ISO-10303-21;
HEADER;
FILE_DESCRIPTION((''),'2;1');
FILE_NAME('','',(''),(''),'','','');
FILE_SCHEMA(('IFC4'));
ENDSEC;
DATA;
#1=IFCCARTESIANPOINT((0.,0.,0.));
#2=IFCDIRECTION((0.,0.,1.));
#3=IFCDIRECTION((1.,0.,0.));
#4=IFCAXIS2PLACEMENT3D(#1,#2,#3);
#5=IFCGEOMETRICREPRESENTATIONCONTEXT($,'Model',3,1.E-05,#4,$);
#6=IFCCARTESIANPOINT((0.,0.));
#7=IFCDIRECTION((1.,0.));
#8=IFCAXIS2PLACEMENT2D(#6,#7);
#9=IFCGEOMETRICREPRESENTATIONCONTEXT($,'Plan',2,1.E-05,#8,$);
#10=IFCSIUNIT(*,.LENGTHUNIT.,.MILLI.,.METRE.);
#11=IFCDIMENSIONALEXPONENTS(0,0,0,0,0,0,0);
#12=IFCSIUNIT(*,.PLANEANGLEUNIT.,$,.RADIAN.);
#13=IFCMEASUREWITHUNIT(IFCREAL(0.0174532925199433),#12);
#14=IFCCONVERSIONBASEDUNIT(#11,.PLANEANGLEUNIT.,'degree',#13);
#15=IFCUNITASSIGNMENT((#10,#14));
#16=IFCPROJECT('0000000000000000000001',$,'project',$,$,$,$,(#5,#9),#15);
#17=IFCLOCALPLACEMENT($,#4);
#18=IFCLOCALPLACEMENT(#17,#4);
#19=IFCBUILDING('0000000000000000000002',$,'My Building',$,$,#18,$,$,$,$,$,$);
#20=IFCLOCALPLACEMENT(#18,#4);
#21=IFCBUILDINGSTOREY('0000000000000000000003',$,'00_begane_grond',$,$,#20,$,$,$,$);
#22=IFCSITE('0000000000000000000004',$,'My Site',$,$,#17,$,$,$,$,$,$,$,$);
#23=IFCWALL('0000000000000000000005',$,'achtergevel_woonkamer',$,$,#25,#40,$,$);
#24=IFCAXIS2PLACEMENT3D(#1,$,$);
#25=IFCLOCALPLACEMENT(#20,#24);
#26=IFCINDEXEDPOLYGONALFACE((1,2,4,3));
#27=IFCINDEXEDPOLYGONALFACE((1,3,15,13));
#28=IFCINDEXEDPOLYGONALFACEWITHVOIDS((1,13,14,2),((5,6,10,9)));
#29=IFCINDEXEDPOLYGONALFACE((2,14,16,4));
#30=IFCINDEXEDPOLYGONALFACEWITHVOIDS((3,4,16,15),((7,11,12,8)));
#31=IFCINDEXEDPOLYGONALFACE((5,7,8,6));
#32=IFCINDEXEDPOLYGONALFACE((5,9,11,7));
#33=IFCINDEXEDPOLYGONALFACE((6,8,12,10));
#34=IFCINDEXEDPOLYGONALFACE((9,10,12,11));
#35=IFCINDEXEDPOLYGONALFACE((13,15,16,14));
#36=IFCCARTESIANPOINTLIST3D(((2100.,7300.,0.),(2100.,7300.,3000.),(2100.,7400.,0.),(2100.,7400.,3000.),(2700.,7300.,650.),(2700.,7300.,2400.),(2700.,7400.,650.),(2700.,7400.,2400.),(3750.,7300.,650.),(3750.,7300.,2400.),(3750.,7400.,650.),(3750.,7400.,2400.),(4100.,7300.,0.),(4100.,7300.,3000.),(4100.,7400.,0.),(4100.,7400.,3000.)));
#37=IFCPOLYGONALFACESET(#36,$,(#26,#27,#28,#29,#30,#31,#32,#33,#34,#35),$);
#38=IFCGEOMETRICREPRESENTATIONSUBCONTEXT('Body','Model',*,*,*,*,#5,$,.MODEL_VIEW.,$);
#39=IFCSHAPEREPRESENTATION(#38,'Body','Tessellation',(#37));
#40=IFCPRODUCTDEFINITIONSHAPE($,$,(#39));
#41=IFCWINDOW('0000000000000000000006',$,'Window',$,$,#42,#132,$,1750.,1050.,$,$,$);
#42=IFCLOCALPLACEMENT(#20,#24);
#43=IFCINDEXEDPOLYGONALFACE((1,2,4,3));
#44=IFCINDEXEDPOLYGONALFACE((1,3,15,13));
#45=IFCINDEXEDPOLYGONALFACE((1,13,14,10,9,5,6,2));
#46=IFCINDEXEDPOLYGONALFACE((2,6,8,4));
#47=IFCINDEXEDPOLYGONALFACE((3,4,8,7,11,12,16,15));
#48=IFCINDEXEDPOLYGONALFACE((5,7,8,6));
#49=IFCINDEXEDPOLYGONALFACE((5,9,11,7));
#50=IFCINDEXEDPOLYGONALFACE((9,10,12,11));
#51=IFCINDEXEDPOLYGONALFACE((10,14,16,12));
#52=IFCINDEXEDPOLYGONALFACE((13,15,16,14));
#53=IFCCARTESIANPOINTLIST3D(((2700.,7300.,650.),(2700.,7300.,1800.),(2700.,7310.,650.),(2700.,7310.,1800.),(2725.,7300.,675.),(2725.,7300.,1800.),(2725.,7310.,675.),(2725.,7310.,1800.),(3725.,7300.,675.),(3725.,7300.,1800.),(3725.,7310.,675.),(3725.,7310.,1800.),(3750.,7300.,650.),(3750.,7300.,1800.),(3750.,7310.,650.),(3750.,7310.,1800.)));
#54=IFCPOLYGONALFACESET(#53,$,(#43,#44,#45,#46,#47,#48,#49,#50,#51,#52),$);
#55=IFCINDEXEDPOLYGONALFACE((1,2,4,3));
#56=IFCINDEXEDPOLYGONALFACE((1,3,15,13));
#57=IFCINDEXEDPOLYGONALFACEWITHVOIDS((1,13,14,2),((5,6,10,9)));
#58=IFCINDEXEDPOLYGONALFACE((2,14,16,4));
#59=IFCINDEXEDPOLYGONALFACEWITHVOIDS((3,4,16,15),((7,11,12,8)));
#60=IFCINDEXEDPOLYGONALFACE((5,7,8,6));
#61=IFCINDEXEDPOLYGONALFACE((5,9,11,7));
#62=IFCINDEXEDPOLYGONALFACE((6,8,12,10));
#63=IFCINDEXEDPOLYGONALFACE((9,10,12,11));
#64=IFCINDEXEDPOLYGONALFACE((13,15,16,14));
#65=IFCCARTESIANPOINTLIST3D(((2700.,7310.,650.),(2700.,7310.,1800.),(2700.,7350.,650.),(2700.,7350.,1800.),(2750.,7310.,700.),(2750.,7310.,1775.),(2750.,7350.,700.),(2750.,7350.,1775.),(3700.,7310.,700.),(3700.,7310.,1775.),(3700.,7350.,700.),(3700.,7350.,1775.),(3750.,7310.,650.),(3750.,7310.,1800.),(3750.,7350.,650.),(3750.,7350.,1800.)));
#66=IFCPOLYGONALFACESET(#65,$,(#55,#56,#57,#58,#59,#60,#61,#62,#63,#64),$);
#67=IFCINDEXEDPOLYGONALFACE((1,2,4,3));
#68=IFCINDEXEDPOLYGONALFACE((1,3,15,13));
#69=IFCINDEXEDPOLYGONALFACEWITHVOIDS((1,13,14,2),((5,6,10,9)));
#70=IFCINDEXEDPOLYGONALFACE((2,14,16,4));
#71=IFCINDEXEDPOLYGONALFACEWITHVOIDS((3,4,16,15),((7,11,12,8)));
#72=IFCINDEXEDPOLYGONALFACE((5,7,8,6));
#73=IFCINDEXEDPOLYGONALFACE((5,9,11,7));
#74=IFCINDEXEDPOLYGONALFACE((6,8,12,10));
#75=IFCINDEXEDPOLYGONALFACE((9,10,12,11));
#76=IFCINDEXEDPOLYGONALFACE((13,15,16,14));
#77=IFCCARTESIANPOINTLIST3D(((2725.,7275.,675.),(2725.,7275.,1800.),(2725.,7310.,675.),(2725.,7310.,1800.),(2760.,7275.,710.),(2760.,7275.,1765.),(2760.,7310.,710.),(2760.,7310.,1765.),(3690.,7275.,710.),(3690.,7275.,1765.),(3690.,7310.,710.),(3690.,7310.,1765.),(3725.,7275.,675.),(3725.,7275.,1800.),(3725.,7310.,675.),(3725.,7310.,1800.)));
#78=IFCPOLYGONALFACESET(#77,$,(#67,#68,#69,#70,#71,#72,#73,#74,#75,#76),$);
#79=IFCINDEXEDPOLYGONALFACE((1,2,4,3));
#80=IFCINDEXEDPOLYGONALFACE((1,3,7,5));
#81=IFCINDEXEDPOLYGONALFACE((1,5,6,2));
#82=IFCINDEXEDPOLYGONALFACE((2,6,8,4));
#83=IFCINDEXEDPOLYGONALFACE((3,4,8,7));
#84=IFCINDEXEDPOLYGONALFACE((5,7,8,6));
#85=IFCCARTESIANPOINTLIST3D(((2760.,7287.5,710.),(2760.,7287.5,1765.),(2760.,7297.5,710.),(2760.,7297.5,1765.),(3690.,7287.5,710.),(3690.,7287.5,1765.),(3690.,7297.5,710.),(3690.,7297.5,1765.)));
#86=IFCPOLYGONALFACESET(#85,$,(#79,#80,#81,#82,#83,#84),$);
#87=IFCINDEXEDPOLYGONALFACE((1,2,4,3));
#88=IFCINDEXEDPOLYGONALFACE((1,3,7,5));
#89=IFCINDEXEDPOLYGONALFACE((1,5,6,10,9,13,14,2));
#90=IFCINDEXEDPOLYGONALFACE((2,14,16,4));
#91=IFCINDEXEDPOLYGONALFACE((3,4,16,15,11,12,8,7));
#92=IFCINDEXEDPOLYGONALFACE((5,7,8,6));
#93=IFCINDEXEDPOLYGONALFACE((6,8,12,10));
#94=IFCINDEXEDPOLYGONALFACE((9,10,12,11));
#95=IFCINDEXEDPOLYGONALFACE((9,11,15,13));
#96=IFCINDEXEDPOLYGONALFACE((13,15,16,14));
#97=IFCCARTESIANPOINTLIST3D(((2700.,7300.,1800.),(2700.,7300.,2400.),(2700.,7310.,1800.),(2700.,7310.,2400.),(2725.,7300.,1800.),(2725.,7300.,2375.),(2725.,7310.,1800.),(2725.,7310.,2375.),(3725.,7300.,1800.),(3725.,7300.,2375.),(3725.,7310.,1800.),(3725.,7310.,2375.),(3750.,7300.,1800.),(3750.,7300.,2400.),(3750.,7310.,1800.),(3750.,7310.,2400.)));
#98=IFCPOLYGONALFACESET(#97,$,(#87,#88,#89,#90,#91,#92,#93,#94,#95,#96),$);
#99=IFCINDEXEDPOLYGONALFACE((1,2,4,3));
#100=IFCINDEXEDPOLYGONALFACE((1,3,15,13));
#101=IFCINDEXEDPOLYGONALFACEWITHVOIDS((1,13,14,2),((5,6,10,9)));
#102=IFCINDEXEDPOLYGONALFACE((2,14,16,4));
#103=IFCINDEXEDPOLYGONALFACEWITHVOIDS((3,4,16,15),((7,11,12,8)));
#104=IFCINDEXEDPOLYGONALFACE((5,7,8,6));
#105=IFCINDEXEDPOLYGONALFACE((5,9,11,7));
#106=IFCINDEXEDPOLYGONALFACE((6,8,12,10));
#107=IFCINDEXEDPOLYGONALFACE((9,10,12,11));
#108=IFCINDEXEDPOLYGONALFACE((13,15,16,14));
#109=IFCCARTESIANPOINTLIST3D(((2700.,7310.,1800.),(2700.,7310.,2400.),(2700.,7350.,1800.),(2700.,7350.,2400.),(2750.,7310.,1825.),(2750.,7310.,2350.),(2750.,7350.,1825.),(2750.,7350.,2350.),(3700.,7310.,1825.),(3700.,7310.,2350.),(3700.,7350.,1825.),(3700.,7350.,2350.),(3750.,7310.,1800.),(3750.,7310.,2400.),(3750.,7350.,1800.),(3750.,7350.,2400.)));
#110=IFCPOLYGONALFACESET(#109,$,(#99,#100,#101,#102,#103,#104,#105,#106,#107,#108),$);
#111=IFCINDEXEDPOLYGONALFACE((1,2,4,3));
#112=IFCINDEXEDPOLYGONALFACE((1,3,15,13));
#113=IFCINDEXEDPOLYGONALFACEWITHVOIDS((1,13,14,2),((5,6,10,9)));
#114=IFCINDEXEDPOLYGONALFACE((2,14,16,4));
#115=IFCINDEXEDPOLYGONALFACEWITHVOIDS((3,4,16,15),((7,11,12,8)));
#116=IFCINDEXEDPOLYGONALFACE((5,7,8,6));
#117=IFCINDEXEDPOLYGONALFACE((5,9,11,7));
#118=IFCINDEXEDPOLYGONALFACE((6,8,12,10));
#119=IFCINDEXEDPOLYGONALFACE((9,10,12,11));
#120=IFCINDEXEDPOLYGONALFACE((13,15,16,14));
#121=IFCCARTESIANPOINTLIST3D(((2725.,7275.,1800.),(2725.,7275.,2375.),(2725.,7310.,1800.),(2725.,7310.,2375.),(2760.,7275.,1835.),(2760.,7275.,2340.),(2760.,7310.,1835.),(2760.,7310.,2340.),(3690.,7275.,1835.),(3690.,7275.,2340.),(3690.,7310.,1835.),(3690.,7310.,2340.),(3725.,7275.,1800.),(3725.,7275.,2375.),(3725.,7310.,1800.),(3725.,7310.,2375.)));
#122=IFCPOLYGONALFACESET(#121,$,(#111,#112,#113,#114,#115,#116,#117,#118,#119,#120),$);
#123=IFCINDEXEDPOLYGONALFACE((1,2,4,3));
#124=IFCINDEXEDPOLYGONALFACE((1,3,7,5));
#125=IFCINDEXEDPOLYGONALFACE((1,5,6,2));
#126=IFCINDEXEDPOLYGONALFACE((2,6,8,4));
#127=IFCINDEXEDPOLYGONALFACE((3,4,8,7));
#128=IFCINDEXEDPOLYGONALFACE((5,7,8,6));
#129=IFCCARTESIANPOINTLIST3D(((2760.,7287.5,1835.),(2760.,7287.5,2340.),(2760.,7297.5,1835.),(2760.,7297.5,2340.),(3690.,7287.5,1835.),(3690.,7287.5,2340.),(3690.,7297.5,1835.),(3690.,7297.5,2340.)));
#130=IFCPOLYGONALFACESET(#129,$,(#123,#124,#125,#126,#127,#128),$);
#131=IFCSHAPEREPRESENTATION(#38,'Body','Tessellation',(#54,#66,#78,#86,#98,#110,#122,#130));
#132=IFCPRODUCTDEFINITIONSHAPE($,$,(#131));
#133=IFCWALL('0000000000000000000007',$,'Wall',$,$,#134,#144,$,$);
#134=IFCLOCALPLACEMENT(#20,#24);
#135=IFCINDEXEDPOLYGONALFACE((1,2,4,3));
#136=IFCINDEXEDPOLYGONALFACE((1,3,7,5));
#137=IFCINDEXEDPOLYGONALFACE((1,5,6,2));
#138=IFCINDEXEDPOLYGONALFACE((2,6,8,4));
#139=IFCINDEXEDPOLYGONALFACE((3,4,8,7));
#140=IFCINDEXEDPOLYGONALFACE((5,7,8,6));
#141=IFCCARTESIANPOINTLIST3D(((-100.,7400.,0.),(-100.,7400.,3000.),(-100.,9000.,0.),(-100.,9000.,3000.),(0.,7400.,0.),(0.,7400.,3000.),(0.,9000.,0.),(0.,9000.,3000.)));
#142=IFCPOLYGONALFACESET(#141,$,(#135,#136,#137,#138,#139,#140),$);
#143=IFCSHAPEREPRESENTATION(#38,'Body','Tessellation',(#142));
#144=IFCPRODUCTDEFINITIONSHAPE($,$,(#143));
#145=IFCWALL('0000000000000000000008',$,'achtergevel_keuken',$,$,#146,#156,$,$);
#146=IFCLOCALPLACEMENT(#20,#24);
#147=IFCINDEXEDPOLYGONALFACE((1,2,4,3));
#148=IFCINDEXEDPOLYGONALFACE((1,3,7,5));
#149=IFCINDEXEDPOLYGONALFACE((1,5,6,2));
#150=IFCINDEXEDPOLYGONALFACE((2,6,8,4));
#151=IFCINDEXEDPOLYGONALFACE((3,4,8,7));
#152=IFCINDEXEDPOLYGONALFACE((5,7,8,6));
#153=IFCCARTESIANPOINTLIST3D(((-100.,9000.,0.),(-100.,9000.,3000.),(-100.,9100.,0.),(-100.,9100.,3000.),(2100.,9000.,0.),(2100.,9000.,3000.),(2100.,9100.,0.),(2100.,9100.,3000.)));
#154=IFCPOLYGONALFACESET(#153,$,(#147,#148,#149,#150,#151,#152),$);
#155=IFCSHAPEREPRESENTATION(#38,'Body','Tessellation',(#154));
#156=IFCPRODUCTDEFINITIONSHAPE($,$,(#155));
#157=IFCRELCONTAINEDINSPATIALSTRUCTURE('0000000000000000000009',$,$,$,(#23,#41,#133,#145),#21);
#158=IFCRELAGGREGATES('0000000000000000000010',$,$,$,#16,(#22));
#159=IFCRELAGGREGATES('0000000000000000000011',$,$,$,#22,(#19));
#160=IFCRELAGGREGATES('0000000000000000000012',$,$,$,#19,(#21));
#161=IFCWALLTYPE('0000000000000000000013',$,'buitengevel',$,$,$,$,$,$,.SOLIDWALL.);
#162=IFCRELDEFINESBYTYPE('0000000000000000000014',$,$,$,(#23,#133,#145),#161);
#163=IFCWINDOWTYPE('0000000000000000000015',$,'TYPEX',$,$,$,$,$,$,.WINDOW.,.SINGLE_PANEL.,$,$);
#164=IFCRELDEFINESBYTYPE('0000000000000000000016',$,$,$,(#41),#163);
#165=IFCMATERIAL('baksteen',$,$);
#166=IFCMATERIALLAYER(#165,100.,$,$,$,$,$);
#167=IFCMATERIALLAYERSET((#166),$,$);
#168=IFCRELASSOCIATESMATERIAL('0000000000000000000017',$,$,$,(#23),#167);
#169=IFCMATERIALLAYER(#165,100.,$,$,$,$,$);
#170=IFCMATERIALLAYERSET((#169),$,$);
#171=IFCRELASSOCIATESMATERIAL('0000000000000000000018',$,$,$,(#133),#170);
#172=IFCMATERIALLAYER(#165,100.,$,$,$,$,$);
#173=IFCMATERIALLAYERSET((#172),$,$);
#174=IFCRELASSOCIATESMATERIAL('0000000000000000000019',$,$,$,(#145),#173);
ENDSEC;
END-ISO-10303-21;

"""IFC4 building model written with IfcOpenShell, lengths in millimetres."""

from ifc_helpers import new_model, entity, si_unit, converted_unit, frame, origin_with_axes, origin_2d_with_axis, place, context, subcontext, project, spatial, line, indexed_curve, outline, extrude, shape, source, transform, mapped, material, layer, layer_set, type_object, type_shapes, element, fill, save


model = new_model("IFC4")

# Units and contexts
model_context = context("Model", 3, precision=1e-05, world=origin_with_axes())
plan_context = context("Plan", 2, precision=1e-05, world=origin_2d_with_axis())
body_context_1 = subcontext(model_context, "Body", "Model", "MODEL_VIEW")
body_context_2 = subcontext(plan_context, "Body", "Plan", "PLAN_VIEW")
ifc_project = project(units=[si_unit("LENGTHUNIT", "METRE", prefix="MILLI"), converted_unit("PLANEANGLEUNIT", "degree", entity("IfcReal", 0.0174532925199433), si_unit("PLANEANGLEUNIT", "RADIAN"), dimensions=[0, 0, 0, 0, 0, 0, 0])], contexts=[model_context, plan_context])

# Site, building, storey
site_placement = place(None, origin_with_axes())
site = spatial("IfcSite", under=ifc_project, at=site_placement, Name="My Site")
building_placement = place(site_placement, origin_with_axes())
building = spatial("IfcBuilding", under=site, at=building_placement, Name="My Building")
storey_placement = place(building_placement, origin_with_axes())
storey = spatial("IfcBuildingStorey", under=building, at=storey_placement, Name="00_begane_grond")

# Shared definitions
wall_type_1 = type_object("IfcWallType", Name="buitengevel", PredefinedType="SOLIDWALL")

# Wall, opening, window
ifc_material_1 = material(Name="baksteen")
ifc_layer_1 = layer(ifc_material_1, 100.0)
ifc_layer_set_1 = layer_set([ifc_layer_1])
wall_1_placement = place(storey_placement, frame((4100.0, 7400.0, 0.0), z_axis=(0.0, 0.0, 1.0), x_axis=(-1.0, 0.0, 0.0)))
wall_1 = element("IfcWall", 1, at=wall_1_placement, inside=storey, type_object=wall_type_1, material=ifc_layer_set_1, Name="achtergevel_woonkamer", context=body_context_1, shape_type="SweptSolid", body=[
    extrude(outline(indexed_curve([(0.0, 0.0), (0.0, 100.0), (2000.0, 100.0), (2000.0, 0.0), (0.0, 0.0)], self_intersect=False)), origin_with_axes(), (0.0, 0.0, 1.0), 3000.0),
])
shared_shape_1 = source(origin_with_axes(), body_context_1, "Body", "SweptSolid", [
    extrude(outline(indexed_curve([(0.0, 0.0), (1050.0, 0.0), (1050.0, 1750.0), (0.0, 1750.0)], segments=[line(1, 2, 3, 4, 1)])), frame((0.0, -100.0, 0.0), z_axis=(0.0, -1.0, 0.0), x_axis=(1.0, 0.0, 0.0)), (0.0, 0.0, -1.0), 300.0),
])
opening_1_placement = place(wall_1_placement, frame((350.0, 0.0, 650.0), z_axis=(0.0, 0.0, 1.0), x_axis=(1.0, 0.0, 0.0)))
opening_1 = element("IfcOpeningElement", 2, at=opening_1_placement, cuts=wall_1, PredefinedType="OPENING", context=body_context_1, shape_type="MappedRepresentation", body=[
    mapped(shared_shape_1, transform((0.0, 0.0, 0.0), x_axis=(1.0, 0.0, 0.0), y_axis=(0.0, 1.0, 0.0), z_axis=(0.0, 0.0, 1.0), scale=1.0)),
])
window_type_1 = type_object("IfcWindowType", Name="TYPEX", PartitioningType="SINGLE_PANEL", PredefinedType="WINDOW")
shared_shape_2 = source(origin_with_axes(), body_context_1, "Body", "SweptSolid", [
    extrude(outline(indexed_curve([(1050.0, 1150.0), (1050.0, 0.0), (0.0, 0.0), (0.0, 1150.0), (25.0, 1150.0), (25.0, 25.0), (1025.0, 25.0), (1025.0, 1150.0)], segments=[line(1, 2, 3, 4, 5, 6, 7, 8, 1)])), frame((0.0, 90.0, 0.0), z_axis=(0.0, -1.0, 0.0), x_axis=(1.0, 0.0, 0.0)), (0.0, 0.0, -1.0), 10.0),
    extrude(outline(indexed_curve([(0.0, 0.0), (1050.0, 0.0), (1050.0, 1150.0), (0.0, 1150.0)], segments=[line(1, 2, 3, 4, 1)]), holes=[indexed_curve([(50.0, 50.0), (1000.0, 50.0), (1000.0, 1125.0), (50.0, 1125.0)], segments=[line(1, 2, 3, 4, 1)])]), frame((0.0, 50.0, 0.0), z_axis=(0.0, -1.0, 0.0), x_axis=(1.0, 0.0, 0.0)), (0.0, 0.0, -1.0), 40.0),
    extrude(outline(indexed_curve([(0.0, 0.0), (1000.0, 0.0), (1000.0, 1125.0), (0.0, 1125.0)], segments=[line(1, 2, 3, 4, 1)]), holes=[indexed_curve([(35.0, 35.0), (965.0, 35.0), (965.0, 1090.0), (35.0, 1090.0)], segments=[line(1, 2, 3, 4, 1)])]), frame((25.0, 90.0, 25.0), z_axis=(0.0, -1.0, 0.0), x_axis=(1.0, 0.0, 0.0)), (0.0, 0.0, -1.0), 35.0),
    extrude(outline(indexed_curve([(35.0, 35.0), (965.0, 35.0), (965.0, 1090.0), (35.0, 1090.0)], segments=[line(1, 2, 3, 4, 1)])), frame((25.0, 102.5, 25.0), z_axis=(0.0, -1.0, 0.0), x_axis=(1.0, 0.0, 0.0)), (0.0, 0.0, -1.0), 10.0),
    extrude(outline(indexed_curve([(0.0, 0.0), (0.0, 600.0), (1050.0, 600.0), (1050.0, 0.0), (1025.0, 0.0), (1025.0, 575.0), (25.0, 575.0), (25.0, 0.0)], segments=[line(1, 2, 3, 4, 5, 6, 7, 8, 1)])), frame((0.0, 90.0, 1150.0), z_axis=(0.0, -1.0, 0.0), x_axis=(1.0, 0.0, 0.0)), (0.0, 0.0, -1.0), 10.0),
    extrude(outline(indexed_curve([(0.0, 0.0), (1050.0, 0.0), (1050.0, 600.0), (0.0, 600.0)], segments=[line(1, 2, 3, 4, 1)]), holes=[indexed_curve([(50.0, 25.0), (1000.0, 25.0), (1000.0, 550.0), (50.0, 550.0)], segments=[line(1, 2, 3, 4, 1)])]), frame((0.0, 50.0, 1150.0), z_axis=(0.0, -1.0, 0.0), x_axis=(1.0, 0.0, 0.0)), (0.0, 0.0, -1.0), 40.0),
    extrude(outline(indexed_curve([(0.0, 0.0), (1000.0, 0.0), (1000.0, 575.0), (0.0, 575.0)], segments=[line(1, 2, 3, 4, 1)]), holes=[indexed_curve([(35.0, 35.0), (965.0, 35.0), (965.0, 540.0), (35.0, 540.0)], segments=[line(1, 2, 3, 4, 1)])]), frame((25.0, 90.0, 1150.0), z_axis=(0.0, -1.0, 0.0), x_axis=(1.0, 0.0, 0.0)), (0.0, 0.0, -1.0), 35.0),
    extrude(outline(indexed_curve([(35.0, 35.0), (965.0, 35.0), (965.0, 540.0), (35.0, 540.0)], segments=[line(1, 2, 3, 4, 1)])), frame((25.0, 102.5, 1150.0), z_axis=(0.0, -1.0, 0.0), x_axis=(1.0, 0.0, 0.0)), (0.0, 0.0, -1.0), 10.0),
])
shared_shape_3 = source(origin_with_axes(), body_context_2, "Body", "Curve2D", [
    entity("IfcIndexedPolyCurve", entity("IfcCartesianPointList2D", [[50.0, 50.0], [1000.0, 50.0]])),
    entity("IfcIndexedPolyCurve", entity("IfcCartesianPointList2D", [[0.0, 100.0], [25.0, 100.0], [25.0, 90.0], [50.0, 90.0], [50.0, 50.0], [0.0, 50.0]]), [entity("IfcLineIndex", [1, 2, 3, 4, 5, 6, 1])]),
    entity("IfcIndexedPolyCurve", entity("IfcCartesianPointList2D", [[1050.0, 100.0], [1025.0, 100.0], [1025.0, 90.0], [1000.0, 90.0], [1000.0, 50.0], [1050.0, 50.0]]), [entity("IfcLineIndex", [1, 2, 3, 4, 5, 6, 1])]),
    entity("IfcIndexedPolyCurve", entity("IfcCartesianPointList2D", [[25.0, 90.0], [60.0, 90.0], [60.0, 125.0], [25.0, 125.0]]), [entity("IfcLineIndex", [1, 2, 3, 4, 1])]),
    entity("IfcIndexedPolyCurve", entity("IfcCartesianPointList2D", [[1025.0, 90.0], [990.0, 90.0], [990.0, 125.0], [1025.0, 125.0]]), [entity("IfcLineIndex", [1, 2, 3, 4, 1])]),
    entity("IfcIndexedPolyCurve", entity("IfcCartesianPointList2D", [[60.0, 90.0], [990.0, 90.0]])),
    entity("IfcIndexedPolyCurve", entity("IfcCartesianPointList2D", [[60.0, 125.0], [990.0, 125.0]])),
    entity("IfcIndexedPolyCurve", entity("IfcCartesianPointList2D", [[60.0, 107.5], [990.0, 107.5]])),
])
type_shapes(window_type_1, [shared_shape_2, shared_shape_3])
window_1_placement = place(opening_1_placement, frame((0.0, 0.0, 0.0), z_axis=(0.0, 0.0, 1.0), x_axis=(1.0, 0.0, 0.0)))
window_1 = element("IfcWindow", 3, at=window_1_placement, inside=storey, type_object=window_type_1, Name="Window", OverallHeight=1750.0, OverallWidth=1050.0, shapes=[
    shape(body_context_1, "Body", "MappedRepresentation", [mapped(shared_shape_2, transform((0.0, 0.0, 0.0), x_axis=(1.0, 0.0, 0.0), y_axis=(0.0, 1.0, 0.0), z_axis=(0.0, 0.0, 1.0), scale=1.0))]),
    shape(body_context_2, "Body", "MappedRepresentation", [mapped(shared_shape_3, transform((0.0, 0.0, 0.0), x_axis=(1.0, 0.0, 0.0), y_axis=(0.0, 1.0, 0.0), z_axis=(0.0, 0.0, 1.0), scale=1.0))]),
])
fill(opening_1, window_1)

# Walls
ifc_layer_2 = layer(ifc_material_1, 100.0)
ifc_layer_set_2 = layer_set([ifc_layer_2])
wall_2_placement = place(storey_placement, frame((0.0, 7400.0, 0.0), z_axis=(0.0, 0.0, 1.0), x_axis=(0.000001, 1.0, 0.0)))
element("IfcWall", 4, at=wall_2_placement, inside=storey, type_object=wall_type_1, material=ifc_layer_set_2, Name="Wall", context=body_context_1, shape_type="SweptSolid", body=[
    extrude(outline(indexed_curve([(0.0, 0.0), (0.0, 100.0), (1600.0, 100.0), (1600.0, 0.0), (0.0, 0.0)], self_intersect=False)), origin_with_axes(), (0.0, 0.0, 1.0), 3000.0),
])
ifc_layer_3 = layer(ifc_material_1, 100.0)
ifc_layer_set_3 = layer_set([ifc_layer_3])
wall_3_placement = place(storey_placement, frame((-100.0, 9000.0, 0.0), z_axis=(0.0, 0.0, 1.0), x_axis=(1.0, -0.000001, 0.0)))
element("IfcWall", 5, at=wall_3_placement, inside=storey, type_object=wall_type_1, material=ifc_layer_set_3, Name="achtergevel_keuken", context=body_context_1, shape_type="SweptSolid", body=[
    extrude(outline(indexed_curve([(0.0, 0.0), (0.0, 100.0), (2200.0, 100.0), (2200.0, 0.0), (0.0, 0.0)], self_intersect=False)), origin_with_axes(), (0.0, 0.0, 1.0), 3000.0),
])

save(model, "model.ifc")
